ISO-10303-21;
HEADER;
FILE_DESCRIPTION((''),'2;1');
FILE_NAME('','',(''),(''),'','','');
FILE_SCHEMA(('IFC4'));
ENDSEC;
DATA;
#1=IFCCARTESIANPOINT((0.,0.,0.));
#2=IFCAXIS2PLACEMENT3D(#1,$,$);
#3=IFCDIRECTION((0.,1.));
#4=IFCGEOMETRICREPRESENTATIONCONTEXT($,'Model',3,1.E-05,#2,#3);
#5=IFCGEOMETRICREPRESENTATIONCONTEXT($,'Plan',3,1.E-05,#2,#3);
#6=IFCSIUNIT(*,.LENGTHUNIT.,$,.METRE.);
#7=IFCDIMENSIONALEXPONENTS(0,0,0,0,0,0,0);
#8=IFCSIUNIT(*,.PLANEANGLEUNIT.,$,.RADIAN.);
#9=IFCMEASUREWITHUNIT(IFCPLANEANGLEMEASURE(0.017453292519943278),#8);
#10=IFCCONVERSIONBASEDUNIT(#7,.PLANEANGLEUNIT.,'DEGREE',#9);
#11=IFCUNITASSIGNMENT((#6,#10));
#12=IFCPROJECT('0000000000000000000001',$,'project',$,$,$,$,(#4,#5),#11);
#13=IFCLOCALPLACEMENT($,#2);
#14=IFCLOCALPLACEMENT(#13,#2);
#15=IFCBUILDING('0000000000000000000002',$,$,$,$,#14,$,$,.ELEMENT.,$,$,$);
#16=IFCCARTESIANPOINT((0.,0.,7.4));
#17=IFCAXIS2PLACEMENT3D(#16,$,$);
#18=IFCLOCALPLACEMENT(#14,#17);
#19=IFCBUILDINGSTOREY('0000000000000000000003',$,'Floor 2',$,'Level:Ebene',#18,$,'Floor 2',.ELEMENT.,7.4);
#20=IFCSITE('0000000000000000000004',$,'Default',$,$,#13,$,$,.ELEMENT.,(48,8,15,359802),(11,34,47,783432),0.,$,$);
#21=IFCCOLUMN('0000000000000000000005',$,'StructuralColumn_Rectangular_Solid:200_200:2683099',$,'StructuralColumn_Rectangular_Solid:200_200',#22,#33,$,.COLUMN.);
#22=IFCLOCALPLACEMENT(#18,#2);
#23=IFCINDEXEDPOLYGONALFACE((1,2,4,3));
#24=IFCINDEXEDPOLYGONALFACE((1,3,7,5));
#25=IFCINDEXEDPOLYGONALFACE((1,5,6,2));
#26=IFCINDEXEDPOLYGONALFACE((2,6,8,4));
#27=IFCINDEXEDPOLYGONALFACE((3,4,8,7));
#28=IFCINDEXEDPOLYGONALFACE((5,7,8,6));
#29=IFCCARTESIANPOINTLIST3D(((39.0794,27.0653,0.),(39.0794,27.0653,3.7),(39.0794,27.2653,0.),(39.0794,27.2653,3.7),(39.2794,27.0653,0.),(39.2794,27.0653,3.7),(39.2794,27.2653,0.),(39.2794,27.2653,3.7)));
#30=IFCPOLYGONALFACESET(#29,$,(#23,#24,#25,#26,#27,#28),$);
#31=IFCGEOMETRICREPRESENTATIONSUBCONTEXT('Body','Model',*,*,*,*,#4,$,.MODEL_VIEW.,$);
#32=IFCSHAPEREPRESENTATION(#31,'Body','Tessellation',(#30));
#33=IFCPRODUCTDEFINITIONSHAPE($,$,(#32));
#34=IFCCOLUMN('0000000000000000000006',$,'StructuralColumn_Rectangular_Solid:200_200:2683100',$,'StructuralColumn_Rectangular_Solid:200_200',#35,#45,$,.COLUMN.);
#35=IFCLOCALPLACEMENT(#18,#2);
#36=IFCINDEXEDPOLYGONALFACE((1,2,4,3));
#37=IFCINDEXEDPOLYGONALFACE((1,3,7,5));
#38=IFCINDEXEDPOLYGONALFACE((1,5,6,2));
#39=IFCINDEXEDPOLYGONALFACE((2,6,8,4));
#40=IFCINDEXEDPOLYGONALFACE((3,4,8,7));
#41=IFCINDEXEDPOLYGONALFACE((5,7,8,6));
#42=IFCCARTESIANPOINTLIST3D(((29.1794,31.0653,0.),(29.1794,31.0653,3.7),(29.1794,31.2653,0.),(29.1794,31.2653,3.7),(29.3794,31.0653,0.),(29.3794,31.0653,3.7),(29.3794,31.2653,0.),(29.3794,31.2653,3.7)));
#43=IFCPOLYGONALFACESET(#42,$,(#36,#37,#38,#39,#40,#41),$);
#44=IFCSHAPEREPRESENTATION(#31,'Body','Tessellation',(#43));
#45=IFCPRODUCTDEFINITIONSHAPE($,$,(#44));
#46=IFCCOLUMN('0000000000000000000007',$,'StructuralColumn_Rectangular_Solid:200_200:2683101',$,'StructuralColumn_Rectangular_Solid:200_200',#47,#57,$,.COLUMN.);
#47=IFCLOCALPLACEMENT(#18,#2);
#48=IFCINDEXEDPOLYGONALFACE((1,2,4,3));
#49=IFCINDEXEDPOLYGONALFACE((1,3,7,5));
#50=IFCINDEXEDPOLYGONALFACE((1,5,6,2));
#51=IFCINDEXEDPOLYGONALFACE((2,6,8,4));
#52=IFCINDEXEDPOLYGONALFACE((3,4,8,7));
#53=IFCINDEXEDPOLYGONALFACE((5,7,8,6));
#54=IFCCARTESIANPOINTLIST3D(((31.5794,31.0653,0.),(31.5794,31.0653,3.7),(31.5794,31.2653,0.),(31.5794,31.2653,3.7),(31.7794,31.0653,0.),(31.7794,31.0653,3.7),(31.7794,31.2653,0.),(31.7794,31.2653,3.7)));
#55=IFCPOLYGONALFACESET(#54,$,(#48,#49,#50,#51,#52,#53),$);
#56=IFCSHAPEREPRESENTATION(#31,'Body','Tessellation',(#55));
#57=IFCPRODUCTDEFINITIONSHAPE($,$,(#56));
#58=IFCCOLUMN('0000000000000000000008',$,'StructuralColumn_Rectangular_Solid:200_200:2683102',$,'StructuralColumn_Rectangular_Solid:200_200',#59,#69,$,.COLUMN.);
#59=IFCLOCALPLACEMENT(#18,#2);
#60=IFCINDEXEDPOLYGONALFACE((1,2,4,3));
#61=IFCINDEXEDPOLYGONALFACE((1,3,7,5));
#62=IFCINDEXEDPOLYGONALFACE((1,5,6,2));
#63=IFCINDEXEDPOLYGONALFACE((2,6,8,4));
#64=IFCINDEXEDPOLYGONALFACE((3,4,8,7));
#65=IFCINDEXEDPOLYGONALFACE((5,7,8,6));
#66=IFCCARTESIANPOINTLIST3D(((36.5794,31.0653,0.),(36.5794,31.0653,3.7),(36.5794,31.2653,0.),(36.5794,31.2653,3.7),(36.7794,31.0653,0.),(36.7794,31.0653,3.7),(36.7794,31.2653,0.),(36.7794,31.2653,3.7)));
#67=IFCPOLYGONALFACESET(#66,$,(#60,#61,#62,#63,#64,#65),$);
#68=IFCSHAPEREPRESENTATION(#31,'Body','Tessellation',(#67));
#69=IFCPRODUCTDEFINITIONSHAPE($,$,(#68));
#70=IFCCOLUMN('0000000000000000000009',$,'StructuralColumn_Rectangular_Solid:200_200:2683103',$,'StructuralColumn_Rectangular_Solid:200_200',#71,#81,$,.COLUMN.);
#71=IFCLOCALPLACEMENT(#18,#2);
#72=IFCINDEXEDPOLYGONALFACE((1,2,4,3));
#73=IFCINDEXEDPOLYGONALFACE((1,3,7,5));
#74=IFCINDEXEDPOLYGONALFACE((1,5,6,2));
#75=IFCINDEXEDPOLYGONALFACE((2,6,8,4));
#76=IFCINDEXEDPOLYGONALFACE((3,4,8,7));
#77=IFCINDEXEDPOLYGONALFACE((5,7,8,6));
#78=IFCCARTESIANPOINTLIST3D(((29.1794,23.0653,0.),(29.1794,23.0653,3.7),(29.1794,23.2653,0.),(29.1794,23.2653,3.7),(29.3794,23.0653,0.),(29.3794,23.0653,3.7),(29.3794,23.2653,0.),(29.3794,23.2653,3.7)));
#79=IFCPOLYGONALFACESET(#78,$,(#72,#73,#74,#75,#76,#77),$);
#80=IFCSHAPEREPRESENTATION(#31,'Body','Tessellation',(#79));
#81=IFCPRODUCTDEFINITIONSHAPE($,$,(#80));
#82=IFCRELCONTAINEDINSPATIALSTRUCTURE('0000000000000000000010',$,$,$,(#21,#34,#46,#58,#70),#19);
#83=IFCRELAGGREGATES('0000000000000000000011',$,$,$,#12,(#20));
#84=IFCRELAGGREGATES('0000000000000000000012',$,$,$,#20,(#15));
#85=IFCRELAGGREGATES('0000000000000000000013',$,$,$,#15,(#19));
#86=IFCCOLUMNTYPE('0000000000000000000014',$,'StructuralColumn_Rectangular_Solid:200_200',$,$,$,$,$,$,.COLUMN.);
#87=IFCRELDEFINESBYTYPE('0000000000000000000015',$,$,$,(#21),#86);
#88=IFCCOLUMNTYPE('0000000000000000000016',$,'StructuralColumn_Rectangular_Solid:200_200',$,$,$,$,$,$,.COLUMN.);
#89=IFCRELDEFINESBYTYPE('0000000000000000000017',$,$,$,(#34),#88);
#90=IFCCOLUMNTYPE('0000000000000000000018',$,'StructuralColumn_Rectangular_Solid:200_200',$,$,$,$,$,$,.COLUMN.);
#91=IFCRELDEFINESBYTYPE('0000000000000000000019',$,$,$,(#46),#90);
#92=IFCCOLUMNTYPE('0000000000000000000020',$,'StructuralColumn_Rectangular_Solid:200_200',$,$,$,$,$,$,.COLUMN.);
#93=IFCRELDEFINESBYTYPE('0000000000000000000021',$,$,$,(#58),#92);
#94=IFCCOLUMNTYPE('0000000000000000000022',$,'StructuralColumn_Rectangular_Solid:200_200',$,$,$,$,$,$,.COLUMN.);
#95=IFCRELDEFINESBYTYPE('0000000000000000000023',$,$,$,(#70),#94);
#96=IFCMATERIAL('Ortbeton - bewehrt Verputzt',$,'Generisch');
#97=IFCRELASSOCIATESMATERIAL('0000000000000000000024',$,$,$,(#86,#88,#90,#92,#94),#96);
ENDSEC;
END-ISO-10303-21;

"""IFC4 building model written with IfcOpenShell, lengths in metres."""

from ifc_helpers import new_model, entity, si_unit, converted_unit, direction, frame, frame_2d, origin, origin_2d_with_axis, place, context, subcontext, project, spatial, rectangle, extrude, source, transform, mapped, material, material_profile, profile_set, type_object, type_shapes, element, save


model = new_model("IFC4")

# Units and contexts
model_context = context("Model", 3, precision=1e-05, world=origin(), true_north=direction((0.0, 1.0)))
plan_context = context("Plan", 3, precision=1e-05, world=origin(), true_north=direction((0.0, 1.0)))
body_context = subcontext(model_context, "Body", "Model", "MODEL_VIEW")
ifc_project = project(units=[si_unit("LENGTHUNIT", "METRE"), converted_unit("PLANEANGLEUNIT", "DEGREE", entity("IfcPlaneAngleMeasure", 0.017453292519943278), si_unit("PLANEANGLEUNIT", "RADIAN"), dimensions=[0, 0, 0, 0, 0, 0, 0])], contexts=[model_context, plan_context])

# Site, building, storey
site_placement = place(None, origin())
site = spatial("IfcSite", under=ifc_project, at=site_placement, Name="Default", CompositionType="ELEMENT", RefLatitude=(48, 8, 15, 359802), RefLongitude=(11, 34, 47, 783432), RefElevation=0.0)
building_placement = place(site_placement, origin())
building = spatial("IfcBuilding", under=site, at=building_placement, CompositionType="ELEMENT")
storey_placement = place(building_placement, frame((0.0, 0.0, 7.4)))
storey = spatial("IfcBuildingStorey", under=building, at=storey_placement, Name="Floor 2", ObjectType="Level:Ebene", LongName="Floor 2", CompositionType="ELEMENT", Elevation=7.4)

# Columns
ifc_material_1 = material(Name="Ortbeton - bewehrt Verputzt", Category="Generisch")
ifc_material_profile = material_profile(ifc_material_1, rectangle(XDim=0.2, YDim=0.2, at=frame_2d((0.0, 0.0), x_axis=(1.0, 0.0))), Name="200_200")
ifc_profile_set = profile_set([ifc_material_profile], Name="200_200")
column_type_1 = type_object("IfcColumnType", Name="StructuralColumn_Rectangular_Solid:200_200", PredefinedType="COLUMN", material=ifc_profile_set)
shared_shape_1 = source(origin(), body_context, "Body", "SweptSolid", [
    extrude(rectangle(XDim=0.2, YDim=0.2, at=frame_2d((0.0, 0.0), x_axis=(1.0, 0.0))), frame((39.1794, 27.1653, 7.4), z_axis=(0.0, 0.0, 1.0), x_axis=(-1.0, 0.0, 0.0)), (0.0, 0.0, 1.0), 3.7),
])
type_shapes(column_type_1, [shared_shape_1])
column_1_placement = place(storey_placement, frame((0.0, 0.0, -7.4)))
element("IfcColumn", 1, at=column_1_placement, inside=storey, type_object=column_type_1, Name="StructuralColumn_Rectangular_Solid:200_200:2683099", ObjectType="StructuralColumn_Rectangular_Solid:200_200", PredefinedType="COLUMN", context=body_context, shape_type="MappedRepresentation", body=[
    mapped(shared_shape_1, transform((0.0, 0.0, 0.0), scale=1.0)),
])
column_type_2 = type_object("IfcColumnType", Name="StructuralColumn_Rectangular_Solid:200_200", PredefinedType="COLUMN", material=ifc_profile_set)
shared_shape_2 = source(origin(), body_context, "Body", "SweptSolid", [
    extrude(rectangle(XDim=0.2, YDim=0.2, at=origin_2d_with_axis()), frame((29.2794, 31.1653, 7.4), z_axis=(0.0, 0.0, 1.0), x_axis=(-1.0, 0.0, 0.0)), (0.0, 0.0, 1.0), 3.7),
])
type_shapes(column_type_2, [shared_shape_2])
column_2_placement = place(storey_placement, frame((0.0, 0.0, -7.4)))
element("IfcColumn", 2, at=column_2_placement, inside=storey, type_object=column_type_2, Name="StructuralColumn_Rectangular_Solid:200_200:2683100", ObjectType="StructuralColumn_Rectangular_Solid:200_200", PredefinedType="COLUMN", context=body_context, shape_type="MappedRepresentation", body=[
    mapped(shared_shape_2, transform((0.0, 0.0, 0.0), scale=1.0)),
])
column_type_3 = type_object("IfcColumnType", Name="StructuralColumn_Rectangular_Solid:200_200", PredefinedType="COLUMN", material=ifc_profile_set)
shared_shape_3 = source(origin(), body_context, "Body", "SweptSolid", [
    extrude(rectangle(XDim=0.2, YDim=0.2, at=origin_2d_with_axis()), frame((31.6794, 31.1653, 7.4), z_axis=(0.0, 0.0, 1.0), x_axis=(-1.0, 0.0, 0.0)), (0.0, 0.0, 1.0), 3.7),
])
type_shapes(column_type_3, [shared_shape_3])
column_3_placement = place(storey_placement, frame((0.0, 0.0, -7.4)))
element("IfcColumn", 3, at=column_3_placement, inside=storey, type_object=column_type_3, Name="StructuralColumn_Rectangular_Solid:200_200:2683101", ObjectType="StructuralColumn_Rectangular_Solid:200_200", PredefinedType="COLUMN", context=body_context, shape_type="MappedRepresentation", body=[
    mapped(shared_shape_3, transform((0.0, 0.0, 0.0), scale=1.0)),
])
column_type_4 = type_object("IfcColumnType", Name="StructuralColumn_Rectangular_Solid:200_200", PredefinedType="COLUMN", material=ifc_profile_set)
shared_shape_4 = source(origin(), body_context, "Body", "SweptSolid", [
    extrude(rectangle(XDim=0.2, YDim=0.2, at=frame_2d((0.0, 0.0), x_axis=(1.0, 0.0))), frame((36.6794, 31.1653, 7.4), z_axis=(0.0, 0.0, 1.0), x_axis=(-1.0, 0.0, 0.0)), (0.0, 0.0, 1.0), 3.7),
])
type_shapes(column_type_4, [shared_shape_4])
column_4_placement = place(storey_placement, frame((0.0, 0.0, -7.4)))
element("IfcColumn", 4, at=column_4_placement, inside=storey, type_object=column_type_4, Name="StructuralColumn_Rectangular_Solid:200_200:2683102", ObjectType="StructuralColumn_Rectangular_Solid:200_200", PredefinedType="COLUMN", context=body_context, shape_type="MappedRepresentation", body=[
    mapped(shared_shape_4, transform((0.0, 0.0, 0.0), scale=1.0)),
])
column_type_5 = type_object("IfcColumnType", Name="StructuralColumn_Rectangular_Solid:200_200", PredefinedType="COLUMN", material=ifc_profile_set)
shared_shape_5 = source(origin(), body_context, "Body", "SweptSolid", [
    extrude(rectangle(XDim=0.2, YDim=0.2, at=origin_2d_with_axis()), frame((29.2794, 23.1653, 7.4), z_axis=(0.0, 0.0, 1.0), x_axis=(-1.0, 0.0, 0.0)), (0.0, 0.0, 1.0), 3.7),
])
type_shapes(column_type_5, [shared_shape_5])
column_5_placement = place(storey_placement, frame((0.0, 0.0, -7.4)))
element("IfcColumn", 5, at=column_5_placement, inside=storey, type_object=column_type_5, Name="StructuralColumn_Rectangular_Solid:200_200:2683103", ObjectType="StructuralColumn_Rectangular_Solid:200_200", PredefinedType="COLUMN", context=body_context, shape_type="MappedRepresentation", body=[
    mapped(shared_shape_5, transform((0.0, 0.0, 0.0), scale=1.0)),
])

save(model, "model.ifc")
